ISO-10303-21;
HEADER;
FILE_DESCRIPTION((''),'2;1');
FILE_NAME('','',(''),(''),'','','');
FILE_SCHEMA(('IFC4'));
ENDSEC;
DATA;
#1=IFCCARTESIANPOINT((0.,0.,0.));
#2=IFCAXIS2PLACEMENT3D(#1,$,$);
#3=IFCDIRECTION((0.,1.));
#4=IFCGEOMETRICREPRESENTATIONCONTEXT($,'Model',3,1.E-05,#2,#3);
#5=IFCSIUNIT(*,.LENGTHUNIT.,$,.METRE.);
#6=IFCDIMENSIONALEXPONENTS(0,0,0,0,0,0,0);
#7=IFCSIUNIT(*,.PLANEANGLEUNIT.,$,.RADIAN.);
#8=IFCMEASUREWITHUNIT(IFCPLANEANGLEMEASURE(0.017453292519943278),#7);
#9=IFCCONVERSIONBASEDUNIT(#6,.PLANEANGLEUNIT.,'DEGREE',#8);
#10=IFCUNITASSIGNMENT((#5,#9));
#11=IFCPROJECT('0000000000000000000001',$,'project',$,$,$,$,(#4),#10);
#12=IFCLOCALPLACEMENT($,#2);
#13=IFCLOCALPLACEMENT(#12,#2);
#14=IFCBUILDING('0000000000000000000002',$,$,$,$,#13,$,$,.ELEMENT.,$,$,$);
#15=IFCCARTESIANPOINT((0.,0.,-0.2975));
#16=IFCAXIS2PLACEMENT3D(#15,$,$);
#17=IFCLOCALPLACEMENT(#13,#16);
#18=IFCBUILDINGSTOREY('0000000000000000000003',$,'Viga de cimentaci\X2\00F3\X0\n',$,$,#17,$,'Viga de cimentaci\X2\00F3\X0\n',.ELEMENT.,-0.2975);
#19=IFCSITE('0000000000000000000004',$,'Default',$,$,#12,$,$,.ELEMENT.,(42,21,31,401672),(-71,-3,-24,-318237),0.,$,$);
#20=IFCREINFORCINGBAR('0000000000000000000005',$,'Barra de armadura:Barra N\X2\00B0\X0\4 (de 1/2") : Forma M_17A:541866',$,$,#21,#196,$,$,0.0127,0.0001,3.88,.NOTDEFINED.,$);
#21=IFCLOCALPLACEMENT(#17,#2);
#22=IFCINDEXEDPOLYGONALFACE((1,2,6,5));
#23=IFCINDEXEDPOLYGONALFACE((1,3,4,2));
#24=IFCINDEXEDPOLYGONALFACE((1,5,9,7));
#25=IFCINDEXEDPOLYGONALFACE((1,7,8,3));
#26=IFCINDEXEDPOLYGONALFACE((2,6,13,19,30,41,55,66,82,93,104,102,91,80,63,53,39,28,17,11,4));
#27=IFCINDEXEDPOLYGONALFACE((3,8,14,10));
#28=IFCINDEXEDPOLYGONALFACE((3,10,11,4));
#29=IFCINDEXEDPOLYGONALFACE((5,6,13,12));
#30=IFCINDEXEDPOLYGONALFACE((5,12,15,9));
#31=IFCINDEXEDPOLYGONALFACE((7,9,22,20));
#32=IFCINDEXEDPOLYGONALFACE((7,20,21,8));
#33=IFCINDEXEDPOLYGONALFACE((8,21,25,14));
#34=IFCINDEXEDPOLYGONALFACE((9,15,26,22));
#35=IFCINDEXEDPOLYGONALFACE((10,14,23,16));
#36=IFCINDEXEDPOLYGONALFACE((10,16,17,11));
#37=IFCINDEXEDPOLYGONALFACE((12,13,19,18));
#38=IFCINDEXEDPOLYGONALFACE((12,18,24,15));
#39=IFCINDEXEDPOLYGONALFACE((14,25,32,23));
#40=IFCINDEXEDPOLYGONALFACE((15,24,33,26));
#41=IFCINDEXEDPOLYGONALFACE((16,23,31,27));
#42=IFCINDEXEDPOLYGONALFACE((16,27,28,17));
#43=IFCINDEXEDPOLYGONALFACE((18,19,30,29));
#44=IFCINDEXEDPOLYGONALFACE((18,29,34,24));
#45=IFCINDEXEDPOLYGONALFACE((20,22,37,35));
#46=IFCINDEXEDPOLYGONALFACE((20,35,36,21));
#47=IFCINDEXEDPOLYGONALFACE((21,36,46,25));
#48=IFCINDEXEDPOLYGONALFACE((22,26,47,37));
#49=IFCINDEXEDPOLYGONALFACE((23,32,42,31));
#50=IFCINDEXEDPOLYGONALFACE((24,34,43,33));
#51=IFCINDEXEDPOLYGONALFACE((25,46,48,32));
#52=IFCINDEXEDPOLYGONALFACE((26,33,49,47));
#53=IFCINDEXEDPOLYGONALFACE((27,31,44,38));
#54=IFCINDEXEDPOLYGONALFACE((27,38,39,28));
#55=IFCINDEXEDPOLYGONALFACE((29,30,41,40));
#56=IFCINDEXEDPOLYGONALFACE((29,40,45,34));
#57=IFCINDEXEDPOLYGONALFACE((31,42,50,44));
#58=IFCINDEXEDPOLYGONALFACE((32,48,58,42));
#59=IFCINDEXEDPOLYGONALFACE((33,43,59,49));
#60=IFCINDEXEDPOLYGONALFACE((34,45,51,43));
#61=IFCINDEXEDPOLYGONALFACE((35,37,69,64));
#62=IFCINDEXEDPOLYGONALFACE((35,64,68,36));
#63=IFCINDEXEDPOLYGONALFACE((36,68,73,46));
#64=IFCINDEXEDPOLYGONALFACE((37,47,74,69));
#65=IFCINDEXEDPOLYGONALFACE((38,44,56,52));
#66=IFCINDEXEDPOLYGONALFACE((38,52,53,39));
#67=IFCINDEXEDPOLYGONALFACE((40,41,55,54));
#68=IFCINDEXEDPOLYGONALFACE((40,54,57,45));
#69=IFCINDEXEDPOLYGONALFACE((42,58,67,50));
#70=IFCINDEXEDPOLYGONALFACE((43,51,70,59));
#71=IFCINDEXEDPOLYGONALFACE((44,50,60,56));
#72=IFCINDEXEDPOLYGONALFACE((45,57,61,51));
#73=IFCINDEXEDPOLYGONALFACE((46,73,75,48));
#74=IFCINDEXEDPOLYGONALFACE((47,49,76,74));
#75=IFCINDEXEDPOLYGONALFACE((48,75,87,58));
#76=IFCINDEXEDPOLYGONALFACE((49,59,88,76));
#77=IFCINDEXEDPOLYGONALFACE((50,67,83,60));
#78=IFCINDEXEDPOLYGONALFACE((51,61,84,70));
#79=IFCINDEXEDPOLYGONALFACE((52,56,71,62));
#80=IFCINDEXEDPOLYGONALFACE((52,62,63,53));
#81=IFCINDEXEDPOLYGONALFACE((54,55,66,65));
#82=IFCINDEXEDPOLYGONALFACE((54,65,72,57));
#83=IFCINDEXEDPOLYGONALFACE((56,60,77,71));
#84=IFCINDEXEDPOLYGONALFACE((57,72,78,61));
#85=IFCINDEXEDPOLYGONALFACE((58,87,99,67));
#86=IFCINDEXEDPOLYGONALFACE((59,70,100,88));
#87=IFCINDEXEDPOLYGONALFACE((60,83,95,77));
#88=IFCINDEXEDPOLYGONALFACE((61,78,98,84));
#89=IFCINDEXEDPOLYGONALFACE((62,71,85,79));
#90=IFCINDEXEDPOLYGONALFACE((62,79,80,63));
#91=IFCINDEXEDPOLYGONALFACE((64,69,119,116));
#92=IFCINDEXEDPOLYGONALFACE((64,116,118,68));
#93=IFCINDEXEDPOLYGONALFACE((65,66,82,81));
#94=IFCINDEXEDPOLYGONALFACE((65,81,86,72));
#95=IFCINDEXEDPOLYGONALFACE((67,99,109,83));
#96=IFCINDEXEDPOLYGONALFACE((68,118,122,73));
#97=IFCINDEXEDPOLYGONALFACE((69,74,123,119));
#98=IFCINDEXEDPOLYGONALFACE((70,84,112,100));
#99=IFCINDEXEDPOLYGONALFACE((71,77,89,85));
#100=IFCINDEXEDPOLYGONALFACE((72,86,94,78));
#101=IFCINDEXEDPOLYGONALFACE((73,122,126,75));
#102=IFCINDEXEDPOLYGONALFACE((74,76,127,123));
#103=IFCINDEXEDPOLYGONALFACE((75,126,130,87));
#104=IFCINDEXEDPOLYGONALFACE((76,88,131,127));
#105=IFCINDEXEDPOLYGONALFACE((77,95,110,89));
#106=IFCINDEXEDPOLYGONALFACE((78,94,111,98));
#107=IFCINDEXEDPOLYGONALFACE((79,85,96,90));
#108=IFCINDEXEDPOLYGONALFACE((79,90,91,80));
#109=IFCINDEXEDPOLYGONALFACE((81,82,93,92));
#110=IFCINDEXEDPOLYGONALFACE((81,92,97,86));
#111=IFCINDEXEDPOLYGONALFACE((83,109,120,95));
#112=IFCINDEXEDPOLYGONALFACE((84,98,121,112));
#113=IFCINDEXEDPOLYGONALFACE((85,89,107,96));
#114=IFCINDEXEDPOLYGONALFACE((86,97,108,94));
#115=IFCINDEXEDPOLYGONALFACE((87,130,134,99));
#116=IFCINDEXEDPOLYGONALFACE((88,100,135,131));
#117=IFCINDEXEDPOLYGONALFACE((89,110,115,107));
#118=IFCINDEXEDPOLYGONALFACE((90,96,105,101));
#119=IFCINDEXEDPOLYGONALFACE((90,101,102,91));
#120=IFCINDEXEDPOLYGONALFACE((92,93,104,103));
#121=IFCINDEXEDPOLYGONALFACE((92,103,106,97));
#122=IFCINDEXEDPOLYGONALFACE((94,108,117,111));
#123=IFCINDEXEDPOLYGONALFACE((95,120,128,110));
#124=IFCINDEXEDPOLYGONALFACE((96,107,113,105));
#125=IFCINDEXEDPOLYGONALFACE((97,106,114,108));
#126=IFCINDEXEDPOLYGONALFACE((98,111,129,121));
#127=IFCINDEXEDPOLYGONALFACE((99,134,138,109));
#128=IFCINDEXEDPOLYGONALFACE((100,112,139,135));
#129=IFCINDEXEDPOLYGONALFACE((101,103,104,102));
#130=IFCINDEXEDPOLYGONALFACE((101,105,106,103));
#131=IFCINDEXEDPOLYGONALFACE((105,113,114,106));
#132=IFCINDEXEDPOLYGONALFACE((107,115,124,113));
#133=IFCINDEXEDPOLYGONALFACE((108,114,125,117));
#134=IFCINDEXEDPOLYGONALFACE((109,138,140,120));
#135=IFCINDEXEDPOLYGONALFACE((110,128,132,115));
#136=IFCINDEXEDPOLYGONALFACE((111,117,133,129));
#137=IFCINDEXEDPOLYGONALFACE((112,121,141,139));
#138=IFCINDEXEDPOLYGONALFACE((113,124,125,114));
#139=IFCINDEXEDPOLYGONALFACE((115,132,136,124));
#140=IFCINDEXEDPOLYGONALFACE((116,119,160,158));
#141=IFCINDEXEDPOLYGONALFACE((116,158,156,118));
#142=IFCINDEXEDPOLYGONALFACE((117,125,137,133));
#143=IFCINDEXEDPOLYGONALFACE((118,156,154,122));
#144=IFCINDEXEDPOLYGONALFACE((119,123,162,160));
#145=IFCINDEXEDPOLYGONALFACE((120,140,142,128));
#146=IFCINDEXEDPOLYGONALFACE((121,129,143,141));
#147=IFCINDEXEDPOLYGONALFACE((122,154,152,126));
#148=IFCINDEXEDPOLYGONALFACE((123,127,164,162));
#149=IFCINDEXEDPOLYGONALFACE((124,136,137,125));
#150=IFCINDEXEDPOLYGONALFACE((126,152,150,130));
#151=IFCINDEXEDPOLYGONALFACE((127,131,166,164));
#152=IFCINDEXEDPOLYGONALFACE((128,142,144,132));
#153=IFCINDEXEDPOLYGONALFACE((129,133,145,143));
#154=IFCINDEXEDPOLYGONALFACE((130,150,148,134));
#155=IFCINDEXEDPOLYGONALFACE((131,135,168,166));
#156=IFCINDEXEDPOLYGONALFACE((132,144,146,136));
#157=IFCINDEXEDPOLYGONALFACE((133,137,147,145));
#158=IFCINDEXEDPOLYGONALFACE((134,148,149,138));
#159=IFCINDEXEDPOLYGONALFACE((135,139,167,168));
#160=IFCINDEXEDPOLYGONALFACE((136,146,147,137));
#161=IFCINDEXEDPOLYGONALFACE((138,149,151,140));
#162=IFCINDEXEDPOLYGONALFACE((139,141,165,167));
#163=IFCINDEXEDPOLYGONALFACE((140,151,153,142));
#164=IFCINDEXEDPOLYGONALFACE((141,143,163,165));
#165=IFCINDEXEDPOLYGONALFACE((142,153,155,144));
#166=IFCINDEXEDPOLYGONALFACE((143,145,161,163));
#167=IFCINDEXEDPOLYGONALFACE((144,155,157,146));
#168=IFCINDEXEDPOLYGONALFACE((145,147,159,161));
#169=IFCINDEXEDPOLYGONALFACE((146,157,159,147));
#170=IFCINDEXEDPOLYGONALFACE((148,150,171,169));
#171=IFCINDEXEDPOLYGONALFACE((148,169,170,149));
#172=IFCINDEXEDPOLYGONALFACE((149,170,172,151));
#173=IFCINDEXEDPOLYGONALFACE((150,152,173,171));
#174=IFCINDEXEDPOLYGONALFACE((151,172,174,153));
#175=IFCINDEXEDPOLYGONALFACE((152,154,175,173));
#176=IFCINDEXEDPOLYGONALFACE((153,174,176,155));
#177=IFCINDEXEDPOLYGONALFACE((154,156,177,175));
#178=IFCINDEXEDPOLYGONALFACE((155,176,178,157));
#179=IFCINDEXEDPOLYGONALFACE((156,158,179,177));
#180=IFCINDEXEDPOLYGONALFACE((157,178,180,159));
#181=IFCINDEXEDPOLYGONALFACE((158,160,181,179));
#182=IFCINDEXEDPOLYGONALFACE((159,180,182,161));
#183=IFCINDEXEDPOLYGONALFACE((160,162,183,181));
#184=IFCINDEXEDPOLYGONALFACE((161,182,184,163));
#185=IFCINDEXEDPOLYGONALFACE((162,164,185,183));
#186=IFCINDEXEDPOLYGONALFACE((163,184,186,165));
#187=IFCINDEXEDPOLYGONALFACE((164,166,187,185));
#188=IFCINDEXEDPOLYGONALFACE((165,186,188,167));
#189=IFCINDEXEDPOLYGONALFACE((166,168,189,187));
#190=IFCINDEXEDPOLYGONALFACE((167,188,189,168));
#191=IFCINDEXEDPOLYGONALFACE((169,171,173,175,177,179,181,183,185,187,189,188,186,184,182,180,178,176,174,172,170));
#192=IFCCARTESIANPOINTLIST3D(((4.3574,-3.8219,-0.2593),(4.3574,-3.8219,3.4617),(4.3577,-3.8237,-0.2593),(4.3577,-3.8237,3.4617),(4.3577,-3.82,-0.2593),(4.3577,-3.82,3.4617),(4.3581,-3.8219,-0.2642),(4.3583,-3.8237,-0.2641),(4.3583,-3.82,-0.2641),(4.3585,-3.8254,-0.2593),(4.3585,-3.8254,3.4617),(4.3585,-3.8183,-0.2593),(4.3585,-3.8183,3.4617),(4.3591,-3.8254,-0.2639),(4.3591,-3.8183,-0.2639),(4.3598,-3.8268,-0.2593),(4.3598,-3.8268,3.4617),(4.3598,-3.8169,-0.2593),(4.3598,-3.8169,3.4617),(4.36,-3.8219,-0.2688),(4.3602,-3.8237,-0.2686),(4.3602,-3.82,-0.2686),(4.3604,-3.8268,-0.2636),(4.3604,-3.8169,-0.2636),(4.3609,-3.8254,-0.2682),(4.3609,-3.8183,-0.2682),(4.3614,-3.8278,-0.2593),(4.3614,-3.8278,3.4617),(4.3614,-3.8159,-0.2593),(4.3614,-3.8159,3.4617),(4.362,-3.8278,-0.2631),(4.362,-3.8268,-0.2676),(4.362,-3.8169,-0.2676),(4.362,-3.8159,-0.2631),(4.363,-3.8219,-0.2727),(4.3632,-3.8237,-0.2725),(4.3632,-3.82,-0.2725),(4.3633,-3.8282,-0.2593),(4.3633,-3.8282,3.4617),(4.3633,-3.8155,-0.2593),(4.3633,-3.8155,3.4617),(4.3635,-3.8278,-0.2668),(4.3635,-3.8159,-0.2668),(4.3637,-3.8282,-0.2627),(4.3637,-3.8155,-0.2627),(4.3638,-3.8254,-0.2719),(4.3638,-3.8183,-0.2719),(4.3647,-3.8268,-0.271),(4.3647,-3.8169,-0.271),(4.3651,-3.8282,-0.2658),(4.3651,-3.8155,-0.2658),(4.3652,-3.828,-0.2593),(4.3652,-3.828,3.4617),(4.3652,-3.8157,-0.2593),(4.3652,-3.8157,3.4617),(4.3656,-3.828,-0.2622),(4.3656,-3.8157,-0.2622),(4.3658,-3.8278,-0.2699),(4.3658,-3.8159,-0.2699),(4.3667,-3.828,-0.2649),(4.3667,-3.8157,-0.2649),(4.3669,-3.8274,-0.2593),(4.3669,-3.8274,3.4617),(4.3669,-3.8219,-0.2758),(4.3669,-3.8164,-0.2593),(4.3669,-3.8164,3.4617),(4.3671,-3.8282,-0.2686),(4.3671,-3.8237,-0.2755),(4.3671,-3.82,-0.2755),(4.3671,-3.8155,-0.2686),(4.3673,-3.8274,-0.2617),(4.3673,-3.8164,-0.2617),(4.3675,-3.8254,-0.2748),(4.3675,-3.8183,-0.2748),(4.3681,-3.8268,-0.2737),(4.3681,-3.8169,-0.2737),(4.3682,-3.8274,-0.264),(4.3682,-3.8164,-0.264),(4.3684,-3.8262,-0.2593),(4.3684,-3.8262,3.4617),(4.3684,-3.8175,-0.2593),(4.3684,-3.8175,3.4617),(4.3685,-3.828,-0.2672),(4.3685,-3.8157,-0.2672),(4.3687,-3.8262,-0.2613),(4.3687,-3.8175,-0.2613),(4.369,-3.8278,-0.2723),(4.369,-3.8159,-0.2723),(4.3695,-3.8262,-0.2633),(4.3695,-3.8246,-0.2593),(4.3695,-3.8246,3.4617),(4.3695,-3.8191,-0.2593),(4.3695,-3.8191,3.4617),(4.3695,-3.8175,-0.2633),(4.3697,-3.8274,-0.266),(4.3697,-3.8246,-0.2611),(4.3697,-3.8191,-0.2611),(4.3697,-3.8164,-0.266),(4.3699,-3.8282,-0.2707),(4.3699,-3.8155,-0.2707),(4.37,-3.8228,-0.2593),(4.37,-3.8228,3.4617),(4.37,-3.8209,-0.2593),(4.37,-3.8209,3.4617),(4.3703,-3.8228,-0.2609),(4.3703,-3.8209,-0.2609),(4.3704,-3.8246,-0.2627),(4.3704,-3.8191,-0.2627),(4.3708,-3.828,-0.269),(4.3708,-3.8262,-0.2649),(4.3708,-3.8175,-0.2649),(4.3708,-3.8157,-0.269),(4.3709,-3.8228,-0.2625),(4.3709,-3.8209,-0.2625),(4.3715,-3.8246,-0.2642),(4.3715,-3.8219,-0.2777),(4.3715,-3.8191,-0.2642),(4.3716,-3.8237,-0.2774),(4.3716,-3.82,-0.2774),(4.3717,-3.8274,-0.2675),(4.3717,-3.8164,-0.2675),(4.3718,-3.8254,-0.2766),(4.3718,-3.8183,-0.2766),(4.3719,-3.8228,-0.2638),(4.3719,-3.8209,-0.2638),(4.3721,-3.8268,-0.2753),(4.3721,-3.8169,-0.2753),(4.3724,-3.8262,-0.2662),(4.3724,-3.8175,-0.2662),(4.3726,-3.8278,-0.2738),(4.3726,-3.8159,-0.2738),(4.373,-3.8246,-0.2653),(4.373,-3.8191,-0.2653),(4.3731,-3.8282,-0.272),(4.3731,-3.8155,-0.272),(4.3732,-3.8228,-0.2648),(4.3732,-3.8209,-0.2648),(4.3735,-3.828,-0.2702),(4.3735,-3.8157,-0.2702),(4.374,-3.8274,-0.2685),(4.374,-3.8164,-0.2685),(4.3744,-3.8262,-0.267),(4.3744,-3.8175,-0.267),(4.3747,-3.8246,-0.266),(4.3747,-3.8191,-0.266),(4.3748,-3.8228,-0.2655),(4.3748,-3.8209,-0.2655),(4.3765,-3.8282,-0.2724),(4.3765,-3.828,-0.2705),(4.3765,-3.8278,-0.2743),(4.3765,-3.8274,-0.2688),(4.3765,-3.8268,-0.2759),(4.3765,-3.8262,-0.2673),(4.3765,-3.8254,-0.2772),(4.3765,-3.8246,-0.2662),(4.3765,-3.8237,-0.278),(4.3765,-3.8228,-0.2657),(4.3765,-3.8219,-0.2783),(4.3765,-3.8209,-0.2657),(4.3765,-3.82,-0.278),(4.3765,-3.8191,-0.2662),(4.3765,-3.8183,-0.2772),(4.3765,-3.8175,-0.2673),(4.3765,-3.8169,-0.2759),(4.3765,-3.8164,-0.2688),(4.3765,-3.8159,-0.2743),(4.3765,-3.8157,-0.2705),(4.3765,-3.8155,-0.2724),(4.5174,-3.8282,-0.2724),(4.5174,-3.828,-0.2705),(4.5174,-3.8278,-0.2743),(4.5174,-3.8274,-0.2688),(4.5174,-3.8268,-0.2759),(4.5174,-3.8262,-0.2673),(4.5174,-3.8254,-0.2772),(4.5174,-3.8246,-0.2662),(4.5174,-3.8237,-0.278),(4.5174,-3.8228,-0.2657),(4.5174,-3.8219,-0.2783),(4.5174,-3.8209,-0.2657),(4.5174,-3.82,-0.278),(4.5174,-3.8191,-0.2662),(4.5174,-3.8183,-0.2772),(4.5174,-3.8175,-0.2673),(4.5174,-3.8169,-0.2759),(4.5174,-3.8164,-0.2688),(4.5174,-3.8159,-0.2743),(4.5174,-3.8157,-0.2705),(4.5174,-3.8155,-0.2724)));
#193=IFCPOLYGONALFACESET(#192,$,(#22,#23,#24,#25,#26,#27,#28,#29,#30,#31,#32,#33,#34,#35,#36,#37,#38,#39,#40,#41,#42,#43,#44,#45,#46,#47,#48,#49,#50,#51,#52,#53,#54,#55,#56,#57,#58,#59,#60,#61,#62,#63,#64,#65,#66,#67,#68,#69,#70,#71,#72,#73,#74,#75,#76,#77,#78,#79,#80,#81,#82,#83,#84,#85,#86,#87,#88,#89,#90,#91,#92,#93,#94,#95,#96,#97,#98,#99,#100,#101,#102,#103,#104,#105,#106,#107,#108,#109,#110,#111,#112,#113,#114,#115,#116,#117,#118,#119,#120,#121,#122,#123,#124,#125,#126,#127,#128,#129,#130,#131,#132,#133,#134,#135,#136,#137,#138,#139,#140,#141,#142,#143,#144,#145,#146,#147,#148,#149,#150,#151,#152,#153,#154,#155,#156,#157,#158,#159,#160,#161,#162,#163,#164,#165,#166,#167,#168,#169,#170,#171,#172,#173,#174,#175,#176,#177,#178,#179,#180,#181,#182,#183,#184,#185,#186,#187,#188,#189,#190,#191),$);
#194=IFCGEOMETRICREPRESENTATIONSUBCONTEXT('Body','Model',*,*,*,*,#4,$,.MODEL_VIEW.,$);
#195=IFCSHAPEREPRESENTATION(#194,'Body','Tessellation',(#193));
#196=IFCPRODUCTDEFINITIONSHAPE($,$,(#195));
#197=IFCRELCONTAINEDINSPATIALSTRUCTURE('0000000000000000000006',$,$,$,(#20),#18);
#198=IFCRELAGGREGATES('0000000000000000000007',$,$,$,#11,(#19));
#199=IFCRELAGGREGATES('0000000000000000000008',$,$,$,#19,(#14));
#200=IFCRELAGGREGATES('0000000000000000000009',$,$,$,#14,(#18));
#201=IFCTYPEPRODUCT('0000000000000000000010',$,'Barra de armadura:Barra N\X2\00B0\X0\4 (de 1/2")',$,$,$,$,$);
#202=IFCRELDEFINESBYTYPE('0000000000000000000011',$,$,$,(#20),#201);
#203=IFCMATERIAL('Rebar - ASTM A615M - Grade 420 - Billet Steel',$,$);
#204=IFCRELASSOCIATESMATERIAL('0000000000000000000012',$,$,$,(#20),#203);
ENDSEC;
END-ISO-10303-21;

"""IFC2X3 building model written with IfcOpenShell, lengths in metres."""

from ifc_helpers import new_model, entity, si_unit, converted_unit, direction, frame, origin, place, context, subcontext, project, spatial, material, type_object, element, save


model = new_model("IFC2X3")

# Units and contexts
model_context = context("Model", 3, precision=1e-05, world=origin(), true_north=direction((0.0, 1.0)))
body_context = subcontext(model_context, "Body", "Model", "MODEL_VIEW")
ifc_project = project(units=[si_unit("LENGTHUNIT", "METRE"), converted_unit("PLANEANGLEUNIT", "DEGREE", entity("IfcPlaneAngleMeasure", 0.017453292519943278), si_unit("PLANEANGLEUNIT", "RADIAN"), dimensions=[0, 0, 0, 0, 0, 0, 0])], contexts=[model_context])

# Site, building, storey
site_placement = place(None, origin())
site = spatial("IfcSite", under=ifc_project, at=site_placement, Name="Default", CompositionType="ELEMENT", RefLatitude=(42, 21, 31, 401672), RefLongitude=(-71, -3, -24, -318237), RefElevation=0.0)
building_placement = place(site_placement, origin())
building = spatial("IfcBuilding", under=site, at=building_placement, CompositionType="ELEMENT")
storey_placement = place(building_placement, frame((0.0, 0.0, -0.2975)))
storey = spatial("IfcBuildingStorey", under=building, at=storey_placement, Name="Viga de cimentación", LongName="Viga de cimentación", CompositionType="ELEMENT", Elevation=-0.2975)

# Reinforcing bar
ifc_material_1 = material(Name="Rebar - ASTM A615M - Grade 420 - Billet Steel")
type_product_1 = type_object("IfcTypeProduct", Name="Barra de armadura:Barra N°4 (de 1/2\")")
reinforcing_bar_1_placement = place(storey_placement, origin())
element("IfcReinforcingBar", 1, at=reinforcing_bar_1_placement, inside=storey, type_object=type_product_1, material=ifc_material_1, Name="Barra de armadura:Barra N°4 (de 1/2\") : Forma M_17A:541866", BarLength=3.88, BarRole="NOTDEFINED", CrossSectionArea=0.0001, NominalDiameter=0.0127, context=body_context, shape_type="AdvancedSweptSolid", body=[
    entity("IfcSweptDiskSolid", entity("IfcCompositeCurve", [entity("IfcCompositeCurveSegment", "CONTINUOUS", True, entity("IfcPolyline", [entity("IfcCartesianPoint", [4.3638, -3.8219, 3.4617]), entity("IfcCartesianPoint", [4.3638, -3.8219, -0.2593])])), entity("IfcCompositeCurveSegment", "CONTINUOUS", True, entity("IfcTrimmedCurve", entity("IfcCircle", entity("IfcAxis2Placement3D", entity("IfcCartesianPoint", [4.3765, -3.8219, -0.2593]), entity("IfcDirection", [0.0, -1.0, 0.0]), entity("IfcDirection", [0.0, 0.0, -1.0])), 0.0127), [entity("IfcParameterValue", 270.0)], [entity("IfcParameterValue", 360.0)], True, "PARAMETER")), entity("IfcCompositeCurveSegment", "CONTINUOUS", True, entity("IfcPolyline", [entity("IfcCartesianPoint", [4.3765, -3.8219, -0.272]), entity("IfcCartesianPoint", [4.5174, -3.8219, -0.272])]))], False), 0.0063, None, 0.0, 92.0),
])

save(model, "model.ifc")
